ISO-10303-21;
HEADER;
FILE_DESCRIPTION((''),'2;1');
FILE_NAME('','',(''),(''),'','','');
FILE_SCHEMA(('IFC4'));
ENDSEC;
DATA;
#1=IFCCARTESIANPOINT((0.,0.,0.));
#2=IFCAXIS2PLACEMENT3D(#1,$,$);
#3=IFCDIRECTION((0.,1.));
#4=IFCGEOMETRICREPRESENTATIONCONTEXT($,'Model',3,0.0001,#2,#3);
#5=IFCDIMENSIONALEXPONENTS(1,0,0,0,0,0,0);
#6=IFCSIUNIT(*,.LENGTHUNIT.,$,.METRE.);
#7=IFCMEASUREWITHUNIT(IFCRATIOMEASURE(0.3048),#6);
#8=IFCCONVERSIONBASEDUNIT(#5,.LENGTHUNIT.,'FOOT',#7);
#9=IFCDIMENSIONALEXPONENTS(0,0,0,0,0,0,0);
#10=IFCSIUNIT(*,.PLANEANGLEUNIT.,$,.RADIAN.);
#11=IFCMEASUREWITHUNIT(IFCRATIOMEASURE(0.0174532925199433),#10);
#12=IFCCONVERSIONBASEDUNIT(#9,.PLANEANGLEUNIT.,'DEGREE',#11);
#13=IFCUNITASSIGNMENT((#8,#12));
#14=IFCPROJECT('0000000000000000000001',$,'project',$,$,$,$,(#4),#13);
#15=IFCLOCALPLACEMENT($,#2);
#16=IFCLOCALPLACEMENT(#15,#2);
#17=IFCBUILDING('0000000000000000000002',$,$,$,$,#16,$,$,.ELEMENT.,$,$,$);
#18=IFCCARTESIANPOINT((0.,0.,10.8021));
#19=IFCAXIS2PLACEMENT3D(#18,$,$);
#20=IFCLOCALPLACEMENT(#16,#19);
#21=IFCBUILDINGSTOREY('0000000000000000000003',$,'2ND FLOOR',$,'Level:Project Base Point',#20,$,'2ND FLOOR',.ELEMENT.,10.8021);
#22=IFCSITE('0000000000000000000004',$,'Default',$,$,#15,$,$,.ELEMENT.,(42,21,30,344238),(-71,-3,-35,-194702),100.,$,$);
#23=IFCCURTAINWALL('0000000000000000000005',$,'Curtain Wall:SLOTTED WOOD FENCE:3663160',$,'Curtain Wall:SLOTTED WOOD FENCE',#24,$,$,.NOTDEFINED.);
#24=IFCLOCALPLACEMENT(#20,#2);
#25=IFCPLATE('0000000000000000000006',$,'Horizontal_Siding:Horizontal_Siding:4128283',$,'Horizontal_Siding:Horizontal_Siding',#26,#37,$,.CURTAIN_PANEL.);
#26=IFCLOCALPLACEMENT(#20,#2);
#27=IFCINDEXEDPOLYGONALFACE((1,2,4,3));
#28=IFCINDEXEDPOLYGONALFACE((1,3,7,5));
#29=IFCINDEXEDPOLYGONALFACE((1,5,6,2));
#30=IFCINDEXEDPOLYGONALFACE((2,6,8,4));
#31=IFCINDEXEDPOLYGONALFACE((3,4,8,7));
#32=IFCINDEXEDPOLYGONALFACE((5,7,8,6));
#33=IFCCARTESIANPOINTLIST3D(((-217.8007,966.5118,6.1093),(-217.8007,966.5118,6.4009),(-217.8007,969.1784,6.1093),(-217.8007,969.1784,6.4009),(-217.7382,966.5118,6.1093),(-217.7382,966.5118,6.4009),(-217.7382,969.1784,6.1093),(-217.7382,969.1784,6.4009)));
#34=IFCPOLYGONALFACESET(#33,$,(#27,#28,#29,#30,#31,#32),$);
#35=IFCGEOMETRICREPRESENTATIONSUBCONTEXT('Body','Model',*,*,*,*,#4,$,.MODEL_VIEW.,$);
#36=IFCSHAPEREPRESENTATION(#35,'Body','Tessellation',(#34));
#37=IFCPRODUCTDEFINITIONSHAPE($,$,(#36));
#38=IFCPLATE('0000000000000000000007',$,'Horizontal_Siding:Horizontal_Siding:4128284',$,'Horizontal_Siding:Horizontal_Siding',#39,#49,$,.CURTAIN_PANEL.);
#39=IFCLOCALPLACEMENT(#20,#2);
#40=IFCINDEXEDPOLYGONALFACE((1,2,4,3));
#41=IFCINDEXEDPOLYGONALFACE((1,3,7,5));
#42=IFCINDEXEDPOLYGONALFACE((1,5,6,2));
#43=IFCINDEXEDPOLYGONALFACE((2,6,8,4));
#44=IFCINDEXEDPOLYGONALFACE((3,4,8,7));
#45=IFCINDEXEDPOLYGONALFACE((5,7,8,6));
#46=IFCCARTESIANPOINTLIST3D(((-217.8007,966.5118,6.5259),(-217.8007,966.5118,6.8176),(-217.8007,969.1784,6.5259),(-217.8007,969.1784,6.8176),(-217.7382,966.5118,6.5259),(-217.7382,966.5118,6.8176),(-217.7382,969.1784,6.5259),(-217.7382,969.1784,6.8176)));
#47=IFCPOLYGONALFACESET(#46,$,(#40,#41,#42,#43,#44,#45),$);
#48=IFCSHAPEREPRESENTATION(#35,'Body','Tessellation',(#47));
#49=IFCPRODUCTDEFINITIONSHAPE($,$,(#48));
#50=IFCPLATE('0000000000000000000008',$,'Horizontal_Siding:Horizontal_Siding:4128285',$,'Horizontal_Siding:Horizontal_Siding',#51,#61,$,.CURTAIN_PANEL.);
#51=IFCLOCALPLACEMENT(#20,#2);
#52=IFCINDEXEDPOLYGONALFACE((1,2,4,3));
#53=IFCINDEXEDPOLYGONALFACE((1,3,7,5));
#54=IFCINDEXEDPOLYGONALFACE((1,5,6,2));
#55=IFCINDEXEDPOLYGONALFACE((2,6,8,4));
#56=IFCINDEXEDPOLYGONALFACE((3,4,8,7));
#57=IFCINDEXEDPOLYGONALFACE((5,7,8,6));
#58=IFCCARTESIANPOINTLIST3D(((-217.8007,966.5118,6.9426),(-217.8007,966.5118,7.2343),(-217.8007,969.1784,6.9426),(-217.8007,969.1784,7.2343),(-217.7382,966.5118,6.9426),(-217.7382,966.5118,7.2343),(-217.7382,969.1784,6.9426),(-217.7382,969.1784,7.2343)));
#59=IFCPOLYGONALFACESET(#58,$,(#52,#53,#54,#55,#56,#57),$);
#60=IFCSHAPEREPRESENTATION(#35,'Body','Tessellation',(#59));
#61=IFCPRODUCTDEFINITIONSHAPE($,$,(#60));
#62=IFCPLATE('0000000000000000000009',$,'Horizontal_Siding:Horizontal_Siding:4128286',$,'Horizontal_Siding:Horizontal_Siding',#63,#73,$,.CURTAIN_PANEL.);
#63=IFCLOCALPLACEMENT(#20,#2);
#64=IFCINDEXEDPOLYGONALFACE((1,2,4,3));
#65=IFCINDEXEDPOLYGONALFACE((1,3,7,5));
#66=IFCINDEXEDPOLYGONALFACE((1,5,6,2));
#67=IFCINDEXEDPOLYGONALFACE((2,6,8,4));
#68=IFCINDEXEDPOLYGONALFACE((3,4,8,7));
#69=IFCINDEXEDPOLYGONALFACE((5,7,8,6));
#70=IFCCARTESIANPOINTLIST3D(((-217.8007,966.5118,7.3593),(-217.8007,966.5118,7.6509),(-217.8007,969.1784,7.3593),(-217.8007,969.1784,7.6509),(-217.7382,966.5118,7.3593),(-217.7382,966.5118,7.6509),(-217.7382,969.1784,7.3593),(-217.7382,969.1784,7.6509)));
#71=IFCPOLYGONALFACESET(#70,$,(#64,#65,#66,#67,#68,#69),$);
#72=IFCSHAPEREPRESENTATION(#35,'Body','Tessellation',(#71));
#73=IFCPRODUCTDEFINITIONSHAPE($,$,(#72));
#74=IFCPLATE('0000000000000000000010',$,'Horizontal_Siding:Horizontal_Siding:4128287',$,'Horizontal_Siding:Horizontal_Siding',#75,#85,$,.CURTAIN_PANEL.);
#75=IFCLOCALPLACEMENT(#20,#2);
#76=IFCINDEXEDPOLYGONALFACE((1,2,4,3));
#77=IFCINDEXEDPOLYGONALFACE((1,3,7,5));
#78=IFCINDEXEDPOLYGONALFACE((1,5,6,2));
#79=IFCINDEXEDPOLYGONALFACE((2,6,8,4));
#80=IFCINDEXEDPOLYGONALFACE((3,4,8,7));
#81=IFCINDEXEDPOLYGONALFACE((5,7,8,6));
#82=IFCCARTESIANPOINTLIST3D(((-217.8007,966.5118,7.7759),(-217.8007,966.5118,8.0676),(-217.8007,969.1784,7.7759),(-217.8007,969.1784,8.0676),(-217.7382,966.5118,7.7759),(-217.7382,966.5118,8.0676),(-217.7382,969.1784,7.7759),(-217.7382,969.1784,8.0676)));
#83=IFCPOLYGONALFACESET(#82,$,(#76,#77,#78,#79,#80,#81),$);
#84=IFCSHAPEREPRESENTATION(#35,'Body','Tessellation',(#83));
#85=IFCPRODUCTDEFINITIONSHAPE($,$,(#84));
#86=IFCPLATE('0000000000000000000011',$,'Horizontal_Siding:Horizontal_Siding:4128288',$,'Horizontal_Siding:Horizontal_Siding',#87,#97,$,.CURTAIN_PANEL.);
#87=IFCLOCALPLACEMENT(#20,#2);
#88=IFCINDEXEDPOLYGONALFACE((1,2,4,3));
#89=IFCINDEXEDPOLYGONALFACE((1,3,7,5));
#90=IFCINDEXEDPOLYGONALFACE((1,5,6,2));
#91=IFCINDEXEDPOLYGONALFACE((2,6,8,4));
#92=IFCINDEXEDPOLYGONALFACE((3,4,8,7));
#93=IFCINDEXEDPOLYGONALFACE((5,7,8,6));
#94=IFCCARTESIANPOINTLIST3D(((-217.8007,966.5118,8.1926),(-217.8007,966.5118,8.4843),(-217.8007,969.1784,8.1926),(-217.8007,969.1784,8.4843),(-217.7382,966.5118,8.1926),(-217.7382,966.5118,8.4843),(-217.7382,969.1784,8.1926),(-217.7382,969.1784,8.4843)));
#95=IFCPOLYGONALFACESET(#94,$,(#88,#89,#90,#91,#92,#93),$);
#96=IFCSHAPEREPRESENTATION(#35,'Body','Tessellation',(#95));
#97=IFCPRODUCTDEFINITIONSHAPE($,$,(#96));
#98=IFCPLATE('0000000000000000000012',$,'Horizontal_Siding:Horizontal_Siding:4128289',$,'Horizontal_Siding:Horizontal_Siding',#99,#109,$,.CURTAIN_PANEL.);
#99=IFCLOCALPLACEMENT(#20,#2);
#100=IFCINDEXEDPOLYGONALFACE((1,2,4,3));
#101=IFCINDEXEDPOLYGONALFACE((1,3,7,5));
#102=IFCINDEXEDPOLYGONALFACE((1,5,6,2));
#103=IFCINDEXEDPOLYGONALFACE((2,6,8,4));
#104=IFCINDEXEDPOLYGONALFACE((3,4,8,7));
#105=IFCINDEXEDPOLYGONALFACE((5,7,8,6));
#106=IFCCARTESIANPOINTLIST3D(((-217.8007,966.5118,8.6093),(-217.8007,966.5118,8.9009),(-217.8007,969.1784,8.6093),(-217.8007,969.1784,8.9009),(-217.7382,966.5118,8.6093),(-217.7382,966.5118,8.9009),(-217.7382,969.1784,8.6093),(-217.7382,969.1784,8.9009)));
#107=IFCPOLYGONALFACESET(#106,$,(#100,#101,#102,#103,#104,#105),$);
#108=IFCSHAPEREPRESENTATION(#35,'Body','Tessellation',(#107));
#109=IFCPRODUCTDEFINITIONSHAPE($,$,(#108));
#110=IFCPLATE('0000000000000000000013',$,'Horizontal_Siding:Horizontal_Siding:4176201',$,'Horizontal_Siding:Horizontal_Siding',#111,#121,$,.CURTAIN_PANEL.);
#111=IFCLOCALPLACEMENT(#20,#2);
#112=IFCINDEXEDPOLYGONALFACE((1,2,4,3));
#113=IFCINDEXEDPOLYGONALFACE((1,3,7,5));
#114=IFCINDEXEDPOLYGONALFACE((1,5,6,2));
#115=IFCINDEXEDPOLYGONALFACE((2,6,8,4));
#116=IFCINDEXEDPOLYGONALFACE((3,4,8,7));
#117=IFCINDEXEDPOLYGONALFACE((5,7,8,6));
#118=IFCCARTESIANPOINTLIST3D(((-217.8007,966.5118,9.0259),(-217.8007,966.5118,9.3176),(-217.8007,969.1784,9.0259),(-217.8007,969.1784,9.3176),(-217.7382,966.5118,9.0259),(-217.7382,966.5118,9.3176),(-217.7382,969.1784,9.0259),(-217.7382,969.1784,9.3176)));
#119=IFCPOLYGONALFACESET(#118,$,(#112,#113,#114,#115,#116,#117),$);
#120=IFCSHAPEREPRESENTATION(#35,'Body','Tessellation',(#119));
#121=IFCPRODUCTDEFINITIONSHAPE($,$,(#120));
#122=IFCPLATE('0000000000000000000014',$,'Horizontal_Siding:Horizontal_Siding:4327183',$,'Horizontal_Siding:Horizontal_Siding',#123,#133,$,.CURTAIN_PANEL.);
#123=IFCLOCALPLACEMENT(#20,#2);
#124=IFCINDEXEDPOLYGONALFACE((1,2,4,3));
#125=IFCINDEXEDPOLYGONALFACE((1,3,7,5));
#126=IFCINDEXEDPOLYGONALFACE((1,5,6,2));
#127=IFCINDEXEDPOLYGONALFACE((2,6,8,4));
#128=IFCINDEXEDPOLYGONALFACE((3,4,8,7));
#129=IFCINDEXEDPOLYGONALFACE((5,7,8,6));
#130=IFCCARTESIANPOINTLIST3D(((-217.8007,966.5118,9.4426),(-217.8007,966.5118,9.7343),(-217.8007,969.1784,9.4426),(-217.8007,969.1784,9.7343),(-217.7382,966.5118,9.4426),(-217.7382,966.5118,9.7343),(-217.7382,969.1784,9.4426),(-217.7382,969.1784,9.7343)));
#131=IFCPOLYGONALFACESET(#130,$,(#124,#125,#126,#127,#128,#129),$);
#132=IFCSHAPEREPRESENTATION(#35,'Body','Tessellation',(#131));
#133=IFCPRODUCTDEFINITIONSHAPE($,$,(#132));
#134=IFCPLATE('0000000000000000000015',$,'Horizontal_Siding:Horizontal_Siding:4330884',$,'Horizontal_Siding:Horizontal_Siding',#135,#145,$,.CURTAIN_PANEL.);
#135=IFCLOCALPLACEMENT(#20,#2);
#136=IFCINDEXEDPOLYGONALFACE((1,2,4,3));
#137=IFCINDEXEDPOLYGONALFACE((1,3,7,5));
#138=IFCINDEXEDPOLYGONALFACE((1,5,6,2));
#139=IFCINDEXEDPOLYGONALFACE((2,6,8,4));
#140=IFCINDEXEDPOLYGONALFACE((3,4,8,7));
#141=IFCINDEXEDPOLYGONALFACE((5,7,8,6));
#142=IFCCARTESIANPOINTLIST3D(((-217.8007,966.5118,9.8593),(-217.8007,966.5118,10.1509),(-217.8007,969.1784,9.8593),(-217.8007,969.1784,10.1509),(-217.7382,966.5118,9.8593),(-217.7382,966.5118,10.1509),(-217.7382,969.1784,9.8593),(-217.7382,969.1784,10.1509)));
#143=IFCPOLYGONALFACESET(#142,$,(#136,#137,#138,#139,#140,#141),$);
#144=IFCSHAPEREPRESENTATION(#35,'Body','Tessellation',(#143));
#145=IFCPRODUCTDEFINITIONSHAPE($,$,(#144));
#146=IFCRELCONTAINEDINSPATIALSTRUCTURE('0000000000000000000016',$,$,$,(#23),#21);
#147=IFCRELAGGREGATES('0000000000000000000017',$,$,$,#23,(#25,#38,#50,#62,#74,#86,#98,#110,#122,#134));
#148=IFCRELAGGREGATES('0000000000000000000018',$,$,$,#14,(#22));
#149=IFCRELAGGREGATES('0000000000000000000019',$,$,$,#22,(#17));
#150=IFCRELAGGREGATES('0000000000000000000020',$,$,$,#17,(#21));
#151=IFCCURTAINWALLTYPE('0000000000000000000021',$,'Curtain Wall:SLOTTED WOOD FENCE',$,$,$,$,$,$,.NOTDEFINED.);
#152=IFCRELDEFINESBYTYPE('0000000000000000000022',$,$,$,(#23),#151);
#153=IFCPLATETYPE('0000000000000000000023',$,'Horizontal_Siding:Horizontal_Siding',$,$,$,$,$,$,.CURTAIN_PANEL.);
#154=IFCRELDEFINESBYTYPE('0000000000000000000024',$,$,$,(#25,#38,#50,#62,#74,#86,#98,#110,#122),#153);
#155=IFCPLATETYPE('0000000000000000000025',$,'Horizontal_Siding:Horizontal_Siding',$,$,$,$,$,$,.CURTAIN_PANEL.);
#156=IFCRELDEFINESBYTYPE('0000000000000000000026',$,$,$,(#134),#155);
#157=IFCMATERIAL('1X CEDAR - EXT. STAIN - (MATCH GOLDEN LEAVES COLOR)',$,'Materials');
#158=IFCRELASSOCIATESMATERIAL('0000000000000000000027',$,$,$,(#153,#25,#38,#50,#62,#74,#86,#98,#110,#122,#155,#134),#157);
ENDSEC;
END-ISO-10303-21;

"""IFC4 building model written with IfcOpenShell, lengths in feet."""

from ifc_helpers import new_model, entity, si_unit, converted_unit, direction, frame, origin, origin_2d_with_axis, place, context, subcontext, project, spatial, rectangle, extrude, source, transform, mapped, material, type_object, type_shapes, element, aggregate, save


model = new_model("IFC4")

# Units and contexts
model_context = context("Model", 3, precision=0.0001, world=origin(), true_north=direction((0.0, 1.0)))
body_context = subcontext(model_context, "Body", "Model", "MODEL_VIEW")
ifc_project = project(units=[converted_unit("LENGTHUNIT", "FOOT", entity("IfcRatioMeasure", 0.3048), si_unit("LENGTHUNIT", "METRE"), dimensions=[1, 0, 0, 0, 0, 0, 0]), converted_unit("PLANEANGLEUNIT", "DEGREE", entity("IfcRatioMeasure", 0.0174532925199433), si_unit("PLANEANGLEUNIT", "RADIAN"), dimensions=[0, 0, 0, 0, 0, 0, 0])], contexts=[model_context])

# Site, building, storey
site_placement = place(None, origin())
site = spatial("IfcSite", under=ifc_project, at=site_placement, Name="Default", CompositionType="ELEMENT", RefLatitude=(42, 21, 30, 344238), RefLongitude=(-71, -3, -35, -194702), RefElevation=100.0)
building_placement = place(site_placement, origin())
building = spatial("IfcBuilding", under=site, at=building_placement, CompositionType="ELEMENT")
storey_placement = place(building_placement, frame((0.0, 0.0, 10.8021)))
storey = spatial("IfcBuildingStorey", under=building, at=storey_placement, Name="2ND FLOOR", ObjectType="Level:Project Base Point", LongName="2ND FLOOR", CompositionType="ELEMENT", Elevation=10.8021)

# Curtain wall, plates
curtain_wall_type = type_object("IfcCurtainWallType", Name="Curtain Wall:SLOTTED WOOD FENCE", PredefinedType="NOTDEFINED")
curtain_wall_placement = place(storey_placement, frame((0.0, 0.0, -10.8021)))
curtain_wall = element("IfcCurtainWall", 1, at=curtain_wall_placement, inside=storey, type_object=curtain_wall_type, Name="Curtain Wall:SLOTTED WOOD FENCE:3663160", ObjectType="Curtain Wall:SLOTTED WOOD FENCE", PredefinedType="NOTDEFINED")
ifc_material_1 = material(Name="1X CEDAR - EXT. STAIN - (MATCH GOLDEN LEAVES COLOR)", Category="Materials")
plate_type_1 = type_object("IfcPlateType", Name="Horizontal_Siding:Horizontal_Siding", PredefinedType="CURTAIN_PANEL", material=ifc_material_1)
shared_shape_1 = source(origin(), body_context, "Body", "SweptSolid", [
    extrude(rectangle(XDim=2.6667, YDim=0.0625, at=origin_2d_with_axis()), frame((1.3333, 0.0312, 0.0), z_axis=(0.0, 0.0, 1.0), x_axis=(-1.0, 0.0, 0.0)), (0.0, 0.0, 1.0), 0.2917),
])
type_shapes(plate_type_1, [shared_shape_1])
plate_1_placement = place(curtain_wall_placement, frame((-217.8007, 969.1784, 16.9113), z_axis=(0.0, 0.0, 1.0), x_axis=(0.0, -1.0, 0.0)))
plate_1 = element("IfcPlate", 2, at=plate_1_placement, type_object=plate_type_1, material=ifc_material_1, Name="Horizontal_Siding:Horizontal_Siding:4128283", ObjectType="Horizontal_Siding:Horizontal_Siding", PredefinedType="CURTAIN_PANEL", context=body_context, shape_type="MappedRepresentation", body=[
    mapped(shared_shape_1, transform((0.0, 0.0, 0.0), scale=1.0)),
])
plate_2_placement = place(curtain_wall_placement, frame((-217.8007, 969.1784, 17.328), z_axis=(0.0, 0.0, 1.0), x_axis=(0.0, -1.0, 0.0)))
plate_2 = element("IfcPlate", 3, at=plate_2_placement, type_object=plate_type_1, material=ifc_material_1, Name="Horizontal_Siding:Horizontal_Siding:4128284", ObjectType="Horizontal_Siding:Horizontal_Siding", PredefinedType="CURTAIN_PANEL", context=body_context, shape_type="MappedRepresentation", body=[
    mapped(shared_shape_1, transform((0.0, 0.0, 0.0), scale=1.0)),
])
plate_3_placement = place(curtain_wall_placement, frame((-217.8007, 969.1784, 17.7447), z_axis=(0.0, 0.0, 1.0), x_axis=(0.0, -1.0, 0.0)))
plate_3 = element("IfcPlate", 4, at=plate_3_placement, type_object=plate_type_1, material=ifc_material_1, Name="Horizontal_Siding:Horizontal_Siding:4128285", ObjectType="Horizontal_Siding:Horizontal_Siding", PredefinedType="CURTAIN_PANEL", context=body_context, shape_type="MappedRepresentation", body=[
    mapped(shared_shape_1, transform((0.0, 0.0, 0.0), scale=1.0)),
])
plate_4_placement = place(curtain_wall_placement, frame((-217.8007, 969.1784, 18.1613), z_axis=(0.0, 0.0, 1.0), x_axis=(0.0, -1.0, 0.0)))
plate_4 = element("IfcPlate", 5, at=plate_4_placement, type_object=plate_type_1, material=ifc_material_1, Name="Horizontal_Siding:Horizontal_Siding:4128286", ObjectType="Horizontal_Siding:Horizontal_Siding", PredefinedType="CURTAIN_PANEL", context=body_context, shape_type="MappedRepresentation", body=[
    mapped(shared_shape_1, transform((0.0, 0.0, 0.0), scale=1.0)),
])
plate_5_placement = place(curtain_wall_placement, frame((-217.8007, 969.1784, 18.578), z_axis=(0.0, 0.0, 1.0), x_axis=(0.0, -1.0, 0.0)))
plate_5 = element("IfcPlate", 6, at=plate_5_placement, type_object=plate_type_1, material=ifc_material_1, Name="Horizontal_Siding:Horizontal_Siding:4128287", ObjectType="Horizontal_Siding:Horizontal_Siding", PredefinedType="CURTAIN_PANEL", context=body_context, shape_type="MappedRepresentation", body=[
    mapped(shared_shape_1, transform((0.0, 0.0, 0.0), scale=1.0)),
])
plate_6_placement = place(curtain_wall_placement, frame((-217.8007, 969.1784, 18.9947), z_axis=(0.0, 0.0, 1.0), x_axis=(0.0, -1.0, 0.0)))
plate_6 = element("IfcPlate", 7, at=plate_6_placement, type_object=plate_type_1, material=ifc_material_1, Name="Horizontal_Siding:Horizontal_Siding:4128288", ObjectType="Horizontal_Siding:Horizontal_Siding", PredefinedType="CURTAIN_PANEL", context=body_context, shape_type="MappedRepresentation", body=[
    mapped(shared_shape_1, transform((0.0, 0.0, 0.0), scale=1.0)),
])
plate_7_placement = place(curtain_wall_placement, frame((-217.8007, 969.1784, 19.4113), z_axis=(0.0, 0.0, 1.0), x_axis=(0.0, -1.0, 0.0)))
plate_7 = element("IfcPlate", 8, at=plate_7_placement, type_object=plate_type_1, material=ifc_material_1, Name="Horizontal_Siding:Horizontal_Siding:4128289", ObjectType="Horizontal_Siding:Horizontal_Siding", PredefinedType="CURTAIN_PANEL", context=body_context, shape_type="MappedRepresentation", body=[
    mapped(shared_shape_1, transform((0.0, 0.0, 0.0), scale=1.0)),
])
plate_8_placement = place(curtain_wall_placement, frame((-217.8007, 969.1784, 19.828), z_axis=(0.0, 0.0, 1.0), x_axis=(0.0, -1.0, 0.0)))
plate_8 = element("IfcPlate", 9, at=plate_8_placement, type_object=plate_type_1, material=ifc_material_1, Name="Horizontal_Siding:Horizontal_Siding:4176201", ObjectType="Horizontal_Siding:Horizontal_Siding", PredefinedType="CURTAIN_PANEL", context=body_context, shape_type="MappedRepresentation", body=[
    mapped(shared_shape_1, transform((0.0, 0.0, 0.0), scale=1.0)),
])
plate_9_placement = place(curtain_wall_placement, frame((-217.8007, 969.1784, 20.2447), z_axis=(0.0, 0.0, 1.0), x_axis=(0.0, -1.0, 0.0)))
plate_9 = element("IfcPlate", 10, at=plate_9_placement, type_object=plate_type_1, material=ifc_material_1, Name="Horizontal_Siding:Horizontal_Siding:4327183", ObjectType="Horizontal_Siding:Horizontal_Siding", PredefinedType="CURTAIN_PANEL", context=body_context, shape_type="MappedRepresentation", body=[
    mapped(shared_shape_1, transform((0.0, 0.0, 0.0), scale=1.0)),
])
plate_type_2 = type_object("IfcPlateType", Name="Horizontal_Siding:Horizontal_Siding", PredefinedType="CURTAIN_PANEL", material=ifc_material_1)
shared_shape_2 = source(origin(), body_context, "Body", "SweptSolid", [
    extrude(rectangle(XDim=2.6667, YDim=0.0625, at=origin_2d_with_axis()), frame((1.3333, 0.0312, 0.0), z_axis=(0.0, 0.0, 1.0), x_axis=(-1.0, 0.0, 0.0)), (0.0, 0.0, 1.0), 0.2917),
])
type_shapes(plate_type_2, [shared_shape_2])
plate_10_placement = place(curtain_wall_placement, frame((-217.8007, 969.1784, 20.6613), z_axis=(0.0, 0.0, 1.0), x_axis=(0.0, -1.0, 0.0)))
plate_10 = element("IfcPlate", 11, at=plate_10_placement, type_object=plate_type_2, material=ifc_material_1, Name="Horizontal_Siding:Horizontal_Siding:4330884", ObjectType="Horizontal_Siding:Horizontal_Siding", PredefinedType="CURTAIN_PANEL", context=body_context, shape_type="MappedRepresentation", body=[
    mapped(shared_shape_2, transform((0.0, 0.0, 0.0), scale=1.0)),
])
aggregate(curtain_wall, [plate_1, plate_2, plate_3, plate_4, plate_5, plate_6, plate_7, plate_8, plate_9, plate_10])

save(model, "model.ifc")
